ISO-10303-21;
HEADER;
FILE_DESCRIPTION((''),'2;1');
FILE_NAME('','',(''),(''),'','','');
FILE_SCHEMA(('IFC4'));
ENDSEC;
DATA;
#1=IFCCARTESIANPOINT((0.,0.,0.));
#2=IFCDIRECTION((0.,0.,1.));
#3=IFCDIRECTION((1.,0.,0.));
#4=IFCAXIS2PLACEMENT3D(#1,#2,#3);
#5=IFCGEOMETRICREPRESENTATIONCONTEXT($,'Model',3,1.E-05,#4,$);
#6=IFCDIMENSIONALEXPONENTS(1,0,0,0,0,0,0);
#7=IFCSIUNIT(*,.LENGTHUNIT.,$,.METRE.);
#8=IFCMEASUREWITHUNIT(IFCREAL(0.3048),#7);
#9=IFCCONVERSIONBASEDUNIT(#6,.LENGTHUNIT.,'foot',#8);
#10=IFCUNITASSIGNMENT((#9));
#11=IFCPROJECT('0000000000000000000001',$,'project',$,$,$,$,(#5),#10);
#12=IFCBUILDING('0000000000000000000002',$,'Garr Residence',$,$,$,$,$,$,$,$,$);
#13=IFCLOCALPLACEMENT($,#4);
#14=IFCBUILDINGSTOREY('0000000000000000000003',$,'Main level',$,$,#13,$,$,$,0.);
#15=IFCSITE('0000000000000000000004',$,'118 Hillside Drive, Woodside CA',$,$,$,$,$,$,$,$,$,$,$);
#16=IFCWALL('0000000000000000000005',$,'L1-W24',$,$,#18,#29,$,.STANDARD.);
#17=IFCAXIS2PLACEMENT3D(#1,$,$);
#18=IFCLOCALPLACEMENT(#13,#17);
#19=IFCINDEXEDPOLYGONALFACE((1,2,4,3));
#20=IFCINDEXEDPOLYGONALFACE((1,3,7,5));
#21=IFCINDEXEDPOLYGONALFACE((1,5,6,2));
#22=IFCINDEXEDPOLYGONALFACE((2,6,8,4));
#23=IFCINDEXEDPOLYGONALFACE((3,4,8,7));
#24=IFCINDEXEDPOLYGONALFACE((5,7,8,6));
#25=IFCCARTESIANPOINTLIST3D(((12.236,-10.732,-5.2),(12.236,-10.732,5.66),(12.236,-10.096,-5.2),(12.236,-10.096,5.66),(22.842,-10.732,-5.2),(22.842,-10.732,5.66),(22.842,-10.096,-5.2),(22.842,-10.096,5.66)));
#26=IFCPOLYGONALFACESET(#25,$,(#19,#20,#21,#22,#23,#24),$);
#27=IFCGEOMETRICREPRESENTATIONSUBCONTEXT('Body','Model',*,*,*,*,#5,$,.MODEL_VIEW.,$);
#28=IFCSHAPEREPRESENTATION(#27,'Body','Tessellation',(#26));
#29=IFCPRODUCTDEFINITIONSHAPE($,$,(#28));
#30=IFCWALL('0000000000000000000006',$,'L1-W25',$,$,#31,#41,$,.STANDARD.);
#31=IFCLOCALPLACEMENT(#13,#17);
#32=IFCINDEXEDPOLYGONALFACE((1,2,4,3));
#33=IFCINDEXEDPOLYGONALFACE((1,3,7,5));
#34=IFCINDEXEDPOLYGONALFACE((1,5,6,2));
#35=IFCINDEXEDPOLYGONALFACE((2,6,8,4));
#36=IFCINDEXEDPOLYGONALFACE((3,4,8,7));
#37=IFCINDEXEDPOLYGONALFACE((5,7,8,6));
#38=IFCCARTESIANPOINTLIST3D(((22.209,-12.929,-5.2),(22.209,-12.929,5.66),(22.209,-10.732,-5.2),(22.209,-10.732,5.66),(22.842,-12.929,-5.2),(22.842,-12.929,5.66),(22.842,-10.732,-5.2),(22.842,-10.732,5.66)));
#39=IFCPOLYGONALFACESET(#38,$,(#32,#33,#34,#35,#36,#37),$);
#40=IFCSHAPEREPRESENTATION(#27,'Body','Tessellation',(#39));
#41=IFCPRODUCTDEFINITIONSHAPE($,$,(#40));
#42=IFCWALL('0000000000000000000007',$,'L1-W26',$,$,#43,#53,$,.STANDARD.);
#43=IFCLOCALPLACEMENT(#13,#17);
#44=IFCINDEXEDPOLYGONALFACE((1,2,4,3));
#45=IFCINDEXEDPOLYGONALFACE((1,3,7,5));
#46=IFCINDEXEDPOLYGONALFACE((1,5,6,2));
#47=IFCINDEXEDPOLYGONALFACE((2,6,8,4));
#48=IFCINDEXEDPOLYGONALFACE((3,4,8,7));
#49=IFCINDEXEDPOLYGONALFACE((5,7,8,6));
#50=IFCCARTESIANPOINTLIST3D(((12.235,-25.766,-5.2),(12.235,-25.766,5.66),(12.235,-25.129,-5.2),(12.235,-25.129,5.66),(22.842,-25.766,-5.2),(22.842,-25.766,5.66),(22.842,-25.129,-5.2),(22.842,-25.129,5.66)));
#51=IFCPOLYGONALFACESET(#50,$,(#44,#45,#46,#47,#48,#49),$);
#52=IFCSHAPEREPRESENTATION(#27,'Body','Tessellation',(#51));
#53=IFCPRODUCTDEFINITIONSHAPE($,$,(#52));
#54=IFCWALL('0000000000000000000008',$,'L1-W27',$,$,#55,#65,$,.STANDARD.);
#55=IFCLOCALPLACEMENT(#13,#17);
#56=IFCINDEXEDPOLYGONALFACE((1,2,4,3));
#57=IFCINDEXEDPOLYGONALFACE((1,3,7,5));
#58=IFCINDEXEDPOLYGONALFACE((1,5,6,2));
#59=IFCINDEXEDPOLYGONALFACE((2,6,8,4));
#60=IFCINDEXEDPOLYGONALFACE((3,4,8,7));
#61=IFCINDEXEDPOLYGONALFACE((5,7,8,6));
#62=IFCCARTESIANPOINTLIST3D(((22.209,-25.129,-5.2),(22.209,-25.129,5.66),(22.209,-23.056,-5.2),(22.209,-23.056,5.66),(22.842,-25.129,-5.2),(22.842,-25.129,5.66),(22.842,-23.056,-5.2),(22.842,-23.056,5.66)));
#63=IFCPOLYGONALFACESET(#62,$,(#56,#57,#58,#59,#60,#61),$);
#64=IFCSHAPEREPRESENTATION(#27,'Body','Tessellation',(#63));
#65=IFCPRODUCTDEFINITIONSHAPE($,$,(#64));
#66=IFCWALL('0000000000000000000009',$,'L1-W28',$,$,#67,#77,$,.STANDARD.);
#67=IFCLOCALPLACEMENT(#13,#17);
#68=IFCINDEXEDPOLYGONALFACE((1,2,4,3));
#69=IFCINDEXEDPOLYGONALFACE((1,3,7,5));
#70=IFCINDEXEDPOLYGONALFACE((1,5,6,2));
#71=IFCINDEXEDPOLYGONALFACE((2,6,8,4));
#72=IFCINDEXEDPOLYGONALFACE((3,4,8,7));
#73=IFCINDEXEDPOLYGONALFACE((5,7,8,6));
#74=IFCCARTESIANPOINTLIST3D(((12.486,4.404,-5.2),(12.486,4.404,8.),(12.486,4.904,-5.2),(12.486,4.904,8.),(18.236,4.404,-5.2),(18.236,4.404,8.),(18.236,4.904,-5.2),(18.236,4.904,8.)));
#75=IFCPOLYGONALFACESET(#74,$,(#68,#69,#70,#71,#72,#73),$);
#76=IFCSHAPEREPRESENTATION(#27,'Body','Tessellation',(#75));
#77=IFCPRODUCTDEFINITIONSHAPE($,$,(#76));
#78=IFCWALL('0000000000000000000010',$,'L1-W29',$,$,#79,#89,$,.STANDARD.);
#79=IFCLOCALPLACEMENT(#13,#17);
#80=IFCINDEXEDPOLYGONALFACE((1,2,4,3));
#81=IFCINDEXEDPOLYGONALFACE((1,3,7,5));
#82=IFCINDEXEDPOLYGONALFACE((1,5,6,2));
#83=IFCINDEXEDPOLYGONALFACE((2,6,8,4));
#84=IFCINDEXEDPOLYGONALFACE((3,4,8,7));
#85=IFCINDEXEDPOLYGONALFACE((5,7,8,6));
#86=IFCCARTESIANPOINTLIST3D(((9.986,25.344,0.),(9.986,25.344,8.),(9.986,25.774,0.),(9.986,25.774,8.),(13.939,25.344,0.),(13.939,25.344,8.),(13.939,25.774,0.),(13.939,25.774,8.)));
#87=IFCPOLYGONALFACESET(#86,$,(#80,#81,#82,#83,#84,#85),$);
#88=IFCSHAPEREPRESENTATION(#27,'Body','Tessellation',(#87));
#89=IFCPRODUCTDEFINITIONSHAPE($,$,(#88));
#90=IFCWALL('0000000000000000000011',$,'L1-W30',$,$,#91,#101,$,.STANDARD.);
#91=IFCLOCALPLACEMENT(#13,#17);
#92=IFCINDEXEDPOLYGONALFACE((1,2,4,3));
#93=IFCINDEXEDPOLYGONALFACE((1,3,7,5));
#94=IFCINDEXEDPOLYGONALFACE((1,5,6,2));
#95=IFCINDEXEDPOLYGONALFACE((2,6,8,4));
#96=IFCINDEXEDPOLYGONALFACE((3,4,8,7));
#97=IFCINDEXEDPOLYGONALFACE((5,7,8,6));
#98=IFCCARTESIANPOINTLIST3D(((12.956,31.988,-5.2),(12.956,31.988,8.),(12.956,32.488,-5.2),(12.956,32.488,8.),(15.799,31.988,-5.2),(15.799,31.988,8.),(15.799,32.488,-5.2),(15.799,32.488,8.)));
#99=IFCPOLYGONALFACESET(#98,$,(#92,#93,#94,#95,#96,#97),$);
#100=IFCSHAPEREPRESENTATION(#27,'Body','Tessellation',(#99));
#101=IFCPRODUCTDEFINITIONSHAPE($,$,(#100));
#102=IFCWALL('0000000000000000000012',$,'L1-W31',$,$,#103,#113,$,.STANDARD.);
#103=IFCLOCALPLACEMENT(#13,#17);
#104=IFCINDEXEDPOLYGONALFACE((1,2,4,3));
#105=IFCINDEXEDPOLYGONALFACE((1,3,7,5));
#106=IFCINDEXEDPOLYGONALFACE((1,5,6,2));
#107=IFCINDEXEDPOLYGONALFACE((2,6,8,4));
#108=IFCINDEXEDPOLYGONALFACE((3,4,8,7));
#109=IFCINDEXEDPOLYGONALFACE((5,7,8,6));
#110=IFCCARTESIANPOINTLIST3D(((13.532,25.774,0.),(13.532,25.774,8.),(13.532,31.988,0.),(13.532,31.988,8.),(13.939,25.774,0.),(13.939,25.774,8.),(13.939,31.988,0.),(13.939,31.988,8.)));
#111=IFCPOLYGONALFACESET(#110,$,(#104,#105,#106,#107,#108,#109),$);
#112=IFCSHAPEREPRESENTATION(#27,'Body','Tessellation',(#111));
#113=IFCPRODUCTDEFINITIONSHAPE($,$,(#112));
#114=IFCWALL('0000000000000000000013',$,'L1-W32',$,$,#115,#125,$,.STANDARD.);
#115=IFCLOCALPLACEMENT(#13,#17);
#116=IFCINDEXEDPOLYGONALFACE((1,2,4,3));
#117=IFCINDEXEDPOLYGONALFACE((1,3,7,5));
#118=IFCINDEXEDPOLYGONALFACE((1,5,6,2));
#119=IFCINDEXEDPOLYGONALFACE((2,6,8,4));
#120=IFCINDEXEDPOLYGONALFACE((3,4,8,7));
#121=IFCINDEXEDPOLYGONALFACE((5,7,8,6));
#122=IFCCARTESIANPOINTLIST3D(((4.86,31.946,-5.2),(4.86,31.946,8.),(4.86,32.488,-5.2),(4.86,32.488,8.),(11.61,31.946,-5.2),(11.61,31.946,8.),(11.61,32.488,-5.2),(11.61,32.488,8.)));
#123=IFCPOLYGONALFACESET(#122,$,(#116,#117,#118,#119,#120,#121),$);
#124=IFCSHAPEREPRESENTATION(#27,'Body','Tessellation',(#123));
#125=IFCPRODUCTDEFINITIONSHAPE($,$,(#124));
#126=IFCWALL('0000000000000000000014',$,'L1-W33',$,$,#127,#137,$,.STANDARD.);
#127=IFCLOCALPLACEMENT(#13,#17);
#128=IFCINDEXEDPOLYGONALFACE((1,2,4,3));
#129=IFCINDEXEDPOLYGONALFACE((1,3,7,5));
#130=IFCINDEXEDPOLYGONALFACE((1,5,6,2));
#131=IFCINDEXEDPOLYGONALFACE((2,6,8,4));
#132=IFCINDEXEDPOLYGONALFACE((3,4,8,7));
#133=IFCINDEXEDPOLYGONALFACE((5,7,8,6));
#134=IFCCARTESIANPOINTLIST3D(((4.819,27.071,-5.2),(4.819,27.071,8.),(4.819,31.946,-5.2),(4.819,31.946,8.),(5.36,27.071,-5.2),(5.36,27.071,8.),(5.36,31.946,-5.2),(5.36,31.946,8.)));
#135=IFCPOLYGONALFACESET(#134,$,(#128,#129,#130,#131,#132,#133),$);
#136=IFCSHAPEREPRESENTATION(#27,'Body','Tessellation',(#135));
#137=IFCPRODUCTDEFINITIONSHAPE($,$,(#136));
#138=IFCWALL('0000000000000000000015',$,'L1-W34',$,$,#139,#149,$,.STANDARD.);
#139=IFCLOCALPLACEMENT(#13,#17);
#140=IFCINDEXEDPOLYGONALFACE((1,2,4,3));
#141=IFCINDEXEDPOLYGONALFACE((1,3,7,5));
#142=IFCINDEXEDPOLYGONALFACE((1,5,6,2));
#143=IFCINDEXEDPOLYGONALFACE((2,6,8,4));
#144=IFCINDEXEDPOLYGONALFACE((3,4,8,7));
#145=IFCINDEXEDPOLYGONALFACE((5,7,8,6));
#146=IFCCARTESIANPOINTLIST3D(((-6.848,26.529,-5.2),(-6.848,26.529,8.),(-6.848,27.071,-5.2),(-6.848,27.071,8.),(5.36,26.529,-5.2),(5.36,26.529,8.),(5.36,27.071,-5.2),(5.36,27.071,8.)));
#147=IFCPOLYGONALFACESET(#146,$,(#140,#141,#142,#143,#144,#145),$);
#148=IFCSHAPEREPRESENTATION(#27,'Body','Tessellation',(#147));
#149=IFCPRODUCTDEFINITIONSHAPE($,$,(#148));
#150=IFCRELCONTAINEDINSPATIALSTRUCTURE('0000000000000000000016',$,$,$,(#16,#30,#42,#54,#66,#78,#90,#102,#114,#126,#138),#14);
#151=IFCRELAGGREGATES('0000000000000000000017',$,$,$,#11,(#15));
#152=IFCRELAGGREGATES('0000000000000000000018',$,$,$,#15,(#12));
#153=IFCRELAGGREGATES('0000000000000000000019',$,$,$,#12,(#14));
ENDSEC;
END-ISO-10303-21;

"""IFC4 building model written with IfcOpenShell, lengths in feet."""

from ifc_helpers import new_model, entity, si_unit, converted_unit, frame, origin, origin_with_axes, place, context, subcontext, project, spatial, polyline, outline, extrude, element, save


model = new_model("IFC4")

# Units and contexts
model_context = context("Model", 3, precision=1e-05, world=origin_with_axes())
body_context = subcontext(model_context, "Body", "Model", "MODEL_VIEW")
ifc_project = project(units=[converted_unit("LENGTHUNIT", "foot", entity("IfcReal", 0.3048), si_unit("LENGTHUNIT", "METRE"), dimensions=[1, 0, 0, 0, 0, 0, 0])], contexts=[model_context])

# Site, building, storey
site = spatial("IfcSite", under=ifc_project, Name="118 Hillside Drive, Woodside CA")
building = spatial("IfcBuilding", under=site, Name="Garr Residence")
storey_placement = place(None, origin_with_axes())
storey = spatial("IfcBuildingStorey", under=building, at=storey_placement, Name="Main level", Elevation=0.0)

# Walls
wall_1_placement = place(storey_placement, frame((0.0, 0.0, -5.2), z_axis=(0.0, 0.0, 1.0), x_axis=(1.0, 0.0, 0.0)))
element("IfcWall", 1, at=wall_1_placement, inside=storey, Name="L1-W24", PredefinedType="STANDARD", context=body_context, shape_type="SweptSolid", body=[
    extrude(outline(polyline([(22.842, -10.732), (22.842, -10.096), (12.236, -10.096), (12.236, -10.732), (22.842, -10.732)])), origin(), (0.0, 0.0, 1.0), 10.86),
])
wall_2_placement = place(storey_placement, frame((0.0, 0.0, -5.2), z_axis=(0.0, 0.0, 1.0), x_axis=(1.0, 0.0, 0.0)))
element("IfcWall", 2, at=wall_2_placement, inside=storey, Name="L1-W25", PredefinedType="STANDARD", context=body_context, shape_type="SweptSolid", body=[
    extrude(outline(polyline([(22.842, -12.929), (22.842, -10.732), (22.209, -10.732), (22.209, -12.929), (22.842, -12.929)])), origin(), (0.0, 0.0, 1.0), 10.86),
])
wall_3_placement = place(storey_placement, frame((0.0, 0.0, -5.2), z_axis=(0.0, 0.0, 1.0), x_axis=(1.0, 0.0, 0.0)))
element("IfcWall", 3, at=wall_3_placement, inside=storey, Name="L1-W26", PredefinedType="STANDARD", context=body_context, shape_type="SweptSolid", body=[
    extrude(outline(polyline([(22.842, -25.766), (22.842, -25.129), (12.235, -25.129), (12.235, -25.766), (22.842, -25.766)])), origin(), (0.0, 0.0, 1.0), 10.86),
])
wall_4_placement = place(storey_placement, frame((0.0, 0.0, -5.2), z_axis=(0.0, 0.0, 1.0), x_axis=(1.0, 0.0, 0.0)))
element("IfcWall", 4, at=wall_4_placement, inside=storey, Name="L1-W27", PredefinedType="STANDARD", context=body_context, shape_type="SweptSolid", body=[
    extrude(outline(polyline([(22.842, -25.129), (22.842, -23.056), (22.209, -23.056), (22.209, -25.129), (22.842, -25.129)])), origin(), (0.0, 0.0, 1.0), 10.86),
])
wall_5_placement = place(storey_placement, frame((0.0, 0.0, -5.2), z_axis=(0.0, 0.0, 1.0), x_axis=(1.0, 0.0, 0.0)))
element("IfcWall", 5, at=wall_5_placement, inside=storey, Name="L1-W28", PredefinedType="STANDARD", context=body_context, shape_type="SweptSolid", body=[
    extrude(outline(polyline([(18.236, 4.404), (18.236, 4.904), (12.486, 4.904), (12.486, 4.404), (18.236, 4.404)])), origin(), (0.0, 0.0, 1.0), 13.2),
])
wall_6_placement = place(storey_placement, origin_with_axes())
element("IfcWall", 6, at=wall_6_placement, inside=storey, Name="L1-W29", PredefinedType="STANDARD", context=body_context, shape_type="SweptSolid", body=[
    extrude(outline(polyline([(13.939, 25.344), (13.939, 25.774), (9.986, 25.774), (9.986, 25.344), (13.939, 25.344)])), origin(), (0.0, 0.0, 1.0), 8.0),
])
wall_7_placement = place(storey_placement, frame((0.0, 0.0, -5.2), z_axis=(0.0, 0.0, 1.0), x_axis=(1.0, 0.0, 0.0)))
element("IfcWall", 7, at=wall_7_placement, inside=storey, Name="L1-W30", PredefinedType="STANDARD", context=body_context, shape_type="SweptSolid", body=[
    extrude(outline(polyline([(15.799, 31.988), (15.799, 32.488), (12.956, 32.488), (12.956, 31.988), (15.799, 31.988)])), origin(), (0.0, 0.0, 1.0), 13.2),
])
wall_8_placement = place(storey_placement, origin_with_axes())
element("IfcWall", 8, at=wall_8_placement, inside=storey, Name="L1-W31", PredefinedType="STANDARD", context=body_context, shape_type="SweptSolid", body=[
    extrude(outline(polyline([(13.939, 25.774), (13.939, 31.988), (13.532, 31.988), (13.532, 25.774), (13.939, 25.774)])), origin(), (0.0, 0.0, 1.0), 8.0),
])
wall_9_placement = place(storey_placement, frame((0.0, 0.0, -5.2), z_axis=(0.0, 0.0, 1.0), x_axis=(1.0, 0.0, 0.0)))
element("IfcWall", 9, at=wall_9_placement, inside=storey, Name="L1-W32", PredefinedType="STANDARD", context=body_context, shape_type="SweptSolid", body=[
    extrude(outline(polyline([(11.61, 31.946), (11.61, 32.488), (4.86, 32.488), (4.86, 31.946), (11.61, 31.946)])), origin(), (0.0, 0.0, 1.0), 13.2),
])
wall_10_placement = place(storey_placement, frame((0.0, 0.0, -5.2), z_axis=(0.0, 0.0, 1.0), x_axis=(1.0, 0.0, 0.0)))
element("IfcWall", 10, at=wall_10_placement, inside=storey, Name="L1-W33", PredefinedType="STANDARD", context=body_context, shape_type="SweptSolid", body=[
    extrude(outline(polyline([(5.36, 27.071), (5.36, 31.946), (4.819, 31.946), (4.819, 27.071), (5.36, 27.071)])), origin(), (0.0, 0.0, 1.0), 13.2),
])
wall_11_placement = place(storey_placement, frame((0.0, 0.0, -5.2), z_axis=(0.0, 0.0, 1.0), x_axis=(1.0, 0.0, 0.0)))
element("IfcWall", 11, at=wall_11_placement, inside=storey, Name="L1-W34", PredefinedType="STANDARD", context=body_context, shape_type="SweptSolid", body=[
    extrude(outline(polyline([(5.36, 26.529), (5.36, 27.071), (-6.848, 27.071), (-6.848, 26.529), (5.36, 26.529)])), origin(), (0.0, 0.0, 1.0), 13.2),
])

save(model, "model.ifc")
